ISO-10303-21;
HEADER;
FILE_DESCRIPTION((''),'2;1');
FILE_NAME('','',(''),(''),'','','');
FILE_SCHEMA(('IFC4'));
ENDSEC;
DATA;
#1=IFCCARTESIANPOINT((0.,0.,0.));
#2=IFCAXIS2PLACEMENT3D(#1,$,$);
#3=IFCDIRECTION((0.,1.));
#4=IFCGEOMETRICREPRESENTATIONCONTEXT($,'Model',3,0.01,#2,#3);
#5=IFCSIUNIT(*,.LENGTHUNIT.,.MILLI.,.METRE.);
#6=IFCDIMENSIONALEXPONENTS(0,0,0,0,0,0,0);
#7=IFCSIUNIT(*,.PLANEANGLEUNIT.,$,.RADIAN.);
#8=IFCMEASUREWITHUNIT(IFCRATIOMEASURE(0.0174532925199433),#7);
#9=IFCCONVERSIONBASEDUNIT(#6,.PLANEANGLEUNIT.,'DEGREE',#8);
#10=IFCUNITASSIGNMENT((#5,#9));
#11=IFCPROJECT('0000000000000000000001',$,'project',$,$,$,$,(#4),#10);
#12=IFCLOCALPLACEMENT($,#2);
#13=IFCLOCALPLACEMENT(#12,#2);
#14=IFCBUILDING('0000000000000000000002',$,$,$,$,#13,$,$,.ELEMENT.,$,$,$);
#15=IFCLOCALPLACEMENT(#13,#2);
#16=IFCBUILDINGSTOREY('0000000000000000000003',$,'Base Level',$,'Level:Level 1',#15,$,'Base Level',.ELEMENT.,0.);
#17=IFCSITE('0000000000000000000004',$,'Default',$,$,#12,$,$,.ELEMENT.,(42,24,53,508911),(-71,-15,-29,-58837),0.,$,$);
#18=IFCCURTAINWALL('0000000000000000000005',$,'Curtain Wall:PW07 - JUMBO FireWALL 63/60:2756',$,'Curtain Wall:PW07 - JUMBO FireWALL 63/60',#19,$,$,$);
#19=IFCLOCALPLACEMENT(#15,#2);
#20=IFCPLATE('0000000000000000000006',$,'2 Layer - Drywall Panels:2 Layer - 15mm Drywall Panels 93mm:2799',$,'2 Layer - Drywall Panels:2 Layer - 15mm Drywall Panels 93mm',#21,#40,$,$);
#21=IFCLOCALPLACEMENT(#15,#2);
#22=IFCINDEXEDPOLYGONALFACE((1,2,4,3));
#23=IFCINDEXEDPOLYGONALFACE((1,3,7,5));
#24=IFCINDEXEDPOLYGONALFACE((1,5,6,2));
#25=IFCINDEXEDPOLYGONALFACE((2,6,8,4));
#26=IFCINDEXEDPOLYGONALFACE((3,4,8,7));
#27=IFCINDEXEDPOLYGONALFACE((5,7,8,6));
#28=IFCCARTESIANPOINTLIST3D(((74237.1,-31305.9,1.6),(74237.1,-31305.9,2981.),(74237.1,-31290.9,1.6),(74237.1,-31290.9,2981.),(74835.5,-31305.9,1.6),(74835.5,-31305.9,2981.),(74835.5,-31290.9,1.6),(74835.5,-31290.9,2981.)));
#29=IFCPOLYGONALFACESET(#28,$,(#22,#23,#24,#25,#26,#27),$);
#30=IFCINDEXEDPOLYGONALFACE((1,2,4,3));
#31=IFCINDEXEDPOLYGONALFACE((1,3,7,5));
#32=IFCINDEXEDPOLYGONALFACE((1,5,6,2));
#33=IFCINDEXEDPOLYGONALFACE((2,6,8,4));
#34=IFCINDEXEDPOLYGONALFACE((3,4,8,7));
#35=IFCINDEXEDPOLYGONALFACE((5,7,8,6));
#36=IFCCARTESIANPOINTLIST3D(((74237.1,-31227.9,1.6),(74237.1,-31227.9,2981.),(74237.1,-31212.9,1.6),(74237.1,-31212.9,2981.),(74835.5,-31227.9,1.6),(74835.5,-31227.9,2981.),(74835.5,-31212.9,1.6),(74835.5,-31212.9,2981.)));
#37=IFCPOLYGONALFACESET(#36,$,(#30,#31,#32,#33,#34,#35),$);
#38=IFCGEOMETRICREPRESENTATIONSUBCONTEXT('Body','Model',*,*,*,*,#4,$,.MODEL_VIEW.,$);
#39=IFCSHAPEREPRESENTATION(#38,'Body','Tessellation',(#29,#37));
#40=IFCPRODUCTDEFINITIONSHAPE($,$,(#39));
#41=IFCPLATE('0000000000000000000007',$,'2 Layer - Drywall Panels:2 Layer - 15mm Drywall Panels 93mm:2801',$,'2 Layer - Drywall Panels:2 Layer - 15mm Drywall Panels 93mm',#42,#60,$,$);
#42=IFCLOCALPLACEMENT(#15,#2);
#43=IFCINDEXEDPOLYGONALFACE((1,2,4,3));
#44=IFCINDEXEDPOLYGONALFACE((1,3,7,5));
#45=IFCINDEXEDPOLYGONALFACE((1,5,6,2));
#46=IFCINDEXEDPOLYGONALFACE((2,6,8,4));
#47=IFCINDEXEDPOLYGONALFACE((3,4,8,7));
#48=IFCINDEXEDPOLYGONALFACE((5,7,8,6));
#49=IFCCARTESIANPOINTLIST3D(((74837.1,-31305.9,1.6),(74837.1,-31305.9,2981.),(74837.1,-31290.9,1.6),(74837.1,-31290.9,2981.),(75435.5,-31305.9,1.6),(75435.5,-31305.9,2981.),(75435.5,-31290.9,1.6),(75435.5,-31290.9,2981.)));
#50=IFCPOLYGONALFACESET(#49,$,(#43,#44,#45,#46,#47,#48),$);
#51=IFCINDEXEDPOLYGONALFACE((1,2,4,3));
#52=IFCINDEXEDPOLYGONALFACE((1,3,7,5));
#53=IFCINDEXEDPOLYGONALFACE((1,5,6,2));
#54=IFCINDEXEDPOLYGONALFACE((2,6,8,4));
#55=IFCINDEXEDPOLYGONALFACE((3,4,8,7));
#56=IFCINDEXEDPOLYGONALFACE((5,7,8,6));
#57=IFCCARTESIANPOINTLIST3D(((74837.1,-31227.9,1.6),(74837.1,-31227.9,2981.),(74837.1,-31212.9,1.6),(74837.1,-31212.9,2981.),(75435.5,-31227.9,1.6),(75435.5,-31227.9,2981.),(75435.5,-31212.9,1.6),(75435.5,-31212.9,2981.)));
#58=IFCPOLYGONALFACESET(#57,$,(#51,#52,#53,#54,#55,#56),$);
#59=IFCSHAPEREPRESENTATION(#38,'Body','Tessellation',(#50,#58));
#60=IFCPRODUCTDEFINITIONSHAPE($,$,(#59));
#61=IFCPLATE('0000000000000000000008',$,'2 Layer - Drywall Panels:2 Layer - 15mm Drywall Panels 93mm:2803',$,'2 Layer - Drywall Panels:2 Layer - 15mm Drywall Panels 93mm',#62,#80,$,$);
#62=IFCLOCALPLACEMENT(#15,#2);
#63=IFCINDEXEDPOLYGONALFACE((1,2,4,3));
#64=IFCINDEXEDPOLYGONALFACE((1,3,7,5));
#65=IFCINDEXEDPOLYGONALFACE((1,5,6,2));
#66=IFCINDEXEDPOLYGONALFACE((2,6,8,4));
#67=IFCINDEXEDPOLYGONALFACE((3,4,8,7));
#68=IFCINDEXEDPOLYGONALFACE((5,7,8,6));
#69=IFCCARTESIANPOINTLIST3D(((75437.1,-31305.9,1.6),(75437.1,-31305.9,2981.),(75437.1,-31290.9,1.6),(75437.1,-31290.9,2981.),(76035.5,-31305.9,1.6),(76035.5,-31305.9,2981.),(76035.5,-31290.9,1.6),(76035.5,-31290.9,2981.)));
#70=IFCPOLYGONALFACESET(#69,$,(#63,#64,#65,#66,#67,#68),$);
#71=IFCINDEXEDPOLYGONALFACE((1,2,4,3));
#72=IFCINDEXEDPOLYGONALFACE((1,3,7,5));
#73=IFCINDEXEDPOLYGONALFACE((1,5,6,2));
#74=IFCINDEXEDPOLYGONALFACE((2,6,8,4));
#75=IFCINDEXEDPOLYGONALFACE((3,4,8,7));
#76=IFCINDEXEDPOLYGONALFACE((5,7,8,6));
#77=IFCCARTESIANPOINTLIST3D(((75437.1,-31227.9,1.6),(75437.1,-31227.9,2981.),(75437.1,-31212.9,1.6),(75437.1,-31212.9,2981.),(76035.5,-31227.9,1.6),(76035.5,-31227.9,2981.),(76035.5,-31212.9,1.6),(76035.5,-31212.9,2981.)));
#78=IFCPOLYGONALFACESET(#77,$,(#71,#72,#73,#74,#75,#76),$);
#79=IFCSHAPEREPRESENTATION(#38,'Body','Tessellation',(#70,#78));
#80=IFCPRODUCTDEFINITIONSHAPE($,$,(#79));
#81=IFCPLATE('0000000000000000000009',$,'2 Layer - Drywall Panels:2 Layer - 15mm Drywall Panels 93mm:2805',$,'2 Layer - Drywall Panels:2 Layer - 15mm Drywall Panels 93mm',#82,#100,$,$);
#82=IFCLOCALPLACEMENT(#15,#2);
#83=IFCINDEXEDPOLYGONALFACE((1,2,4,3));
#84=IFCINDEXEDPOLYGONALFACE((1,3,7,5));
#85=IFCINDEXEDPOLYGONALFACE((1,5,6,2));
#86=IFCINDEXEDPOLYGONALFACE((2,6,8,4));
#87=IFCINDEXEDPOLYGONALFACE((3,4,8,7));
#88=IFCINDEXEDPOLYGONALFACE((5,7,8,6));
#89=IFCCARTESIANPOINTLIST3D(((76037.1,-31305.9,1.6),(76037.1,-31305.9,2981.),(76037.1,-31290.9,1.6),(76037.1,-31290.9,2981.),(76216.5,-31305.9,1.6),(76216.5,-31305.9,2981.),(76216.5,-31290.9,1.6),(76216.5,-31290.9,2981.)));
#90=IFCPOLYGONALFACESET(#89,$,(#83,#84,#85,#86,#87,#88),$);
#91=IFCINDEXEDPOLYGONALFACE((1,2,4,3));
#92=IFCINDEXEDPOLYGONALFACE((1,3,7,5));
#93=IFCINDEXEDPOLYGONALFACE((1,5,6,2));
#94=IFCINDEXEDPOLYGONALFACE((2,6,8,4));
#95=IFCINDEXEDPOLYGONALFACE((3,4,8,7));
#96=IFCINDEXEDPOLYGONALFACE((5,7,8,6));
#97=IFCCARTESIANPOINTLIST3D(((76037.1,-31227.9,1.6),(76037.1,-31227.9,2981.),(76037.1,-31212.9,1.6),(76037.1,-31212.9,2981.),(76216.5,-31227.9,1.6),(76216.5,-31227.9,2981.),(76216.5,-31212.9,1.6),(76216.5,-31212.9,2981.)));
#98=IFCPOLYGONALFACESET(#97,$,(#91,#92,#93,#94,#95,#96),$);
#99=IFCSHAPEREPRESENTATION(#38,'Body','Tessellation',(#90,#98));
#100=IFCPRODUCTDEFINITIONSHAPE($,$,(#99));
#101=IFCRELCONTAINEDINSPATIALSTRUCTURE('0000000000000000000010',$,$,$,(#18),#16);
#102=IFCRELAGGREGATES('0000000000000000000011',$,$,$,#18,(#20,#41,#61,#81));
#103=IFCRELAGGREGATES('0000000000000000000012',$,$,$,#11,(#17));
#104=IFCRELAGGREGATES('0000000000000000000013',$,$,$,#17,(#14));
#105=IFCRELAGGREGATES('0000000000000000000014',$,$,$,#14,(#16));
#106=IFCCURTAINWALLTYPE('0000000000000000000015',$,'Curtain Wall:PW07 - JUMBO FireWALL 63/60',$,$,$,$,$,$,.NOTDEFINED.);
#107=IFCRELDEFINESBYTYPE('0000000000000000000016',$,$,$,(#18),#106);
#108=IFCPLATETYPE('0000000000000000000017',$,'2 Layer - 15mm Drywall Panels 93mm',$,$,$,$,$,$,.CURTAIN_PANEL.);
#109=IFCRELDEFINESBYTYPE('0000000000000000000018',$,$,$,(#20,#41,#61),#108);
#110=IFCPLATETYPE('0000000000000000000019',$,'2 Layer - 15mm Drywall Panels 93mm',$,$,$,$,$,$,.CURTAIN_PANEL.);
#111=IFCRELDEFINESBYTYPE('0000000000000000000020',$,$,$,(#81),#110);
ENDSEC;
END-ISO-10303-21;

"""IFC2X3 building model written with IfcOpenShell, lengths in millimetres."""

from ifc_helpers import new_model, entity, si_unit, converted_unit, direction, frame, frame_2d, origin, place, context, subcontext, project, spatial, rectangle, extrude, source, transform, mapped, type_object, type_shapes, element, aggregate, save


model = new_model("IFC2X3")

# Units and contexts
model_context = context("Model", 3, precision=0.01, world=origin(), true_north=direction((0.0, 1.0)))
body_context = subcontext(model_context, "Body", "Model", "MODEL_VIEW")
ifc_project = project(units=[si_unit("LENGTHUNIT", "METRE", prefix="MILLI"), converted_unit("PLANEANGLEUNIT", "DEGREE", entity("IfcRatioMeasure", 0.0174532925199433), si_unit("PLANEANGLEUNIT", "RADIAN"), dimensions=[0, 0, 0, 0, 0, 0, 0])], contexts=[model_context])

# Site, building, storey
site_placement = place(None, origin())
site = spatial("IfcSite", under=ifc_project, at=site_placement, Name="Default", CompositionType="ELEMENT", RefLatitude=(42, 24, 53, 508911), RefLongitude=(-71, -15, -29, -58837), RefElevation=0.0)
building_placement = place(site_placement, origin())
building = spatial("IfcBuilding", under=site, at=building_placement, CompositionType="ELEMENT")
storey_placement = place(building_placement, origin())
storey = spatial("IfcBuildingStorey", under=building, at=storey_placement, Name="Base Level", ObjectType="Level:Level 1", LongName="Base Level", CompositionType="ELEMENT", Elevation=0.0)

# Curtain wall, plates
curtain_wall_type = type_object("IfcCurtainWallType", Name="Curtain Wall:PW07 - JUMBO FireWALL 63/60", PredefinedType="NOTDEFINED")
curtain_wall_placement = place(building_placement, origin())
curtain_wall = element("IfcCurtainWall", 1, at=curtain_wall_placement, inside=storey, type_object=curtain_wall_type, Name="Curtain Wall:PW07 - JUMBO FireWALL 63/60:2756", ObjectType="Curtain Wall:PW07 - JUMBO FireWALL 63/60")
plate_type_1 = type_object("IfcPlateType", Name="2 Layer - 15mm Drywall Panels 93mm", PredefinedType="CURTAIN_PANEL")
shared_shape_1 = source(origin(), body_context, "Body", "SweptSolid", [
    extrude(rectangle(XDim=598.4, YDim=15.0, at=frame_2d((0.0, 0.0), x_axis=(1.0, 0.0))), frame((0.0, -39.0, 0.0), z_axis=(0.0, 0.0, 1.0), x_axis=(-1.0, 0.0, 0.0)), (0.0, 0.0, 1.0), 2979.4),
    extrude(rectangle(XDim=15.0, YDim=598.4, at=frame_2d((0.0, 0.0), x_axis=(1.0, 0.0))), frame((0.0, 39.0, 0.0), z_axis=(0.0, 0.0, 1.0), x_axis=(0.0, 1.0, 0.0)), (0.0, 0.0, 1.0), 2979.4),
])
type_shapes(plate_type_1, [shared_shape_1])
plate_1_placement = place(curtain_wall_placement, frame((74536.3, -31259.4, 1.6)))
plate_1 = element("IfcPlate", 2, at=plate_1_placement, type_object=plate_type_1, Name="2 Layer - Drywall Panels:2 Layer - 15mm Drywall Panels 93mm:2799", ObjectType="2 Layer - Drywall Panels:2 Layer - 15mm Drywall Panels 93mm", context=body_context, shape_type="MappedRepresentation", body=[
    mapped(shared_shape_1, transform((0.0, 0.0, 0.0), scale=1.0)),
])
plate_2_placement = place(curtain_wall_placement, frame((75136.3, -31259.4, 1.6)))
plate_2 = element("IfcPlate", 3, at=plate_2_placement, type_object=plate_type_1, Name="2 Layer - Drywall Panels:2 Layer - 15mm Drywall Panels 93mm:2801", ObjectType="2 Layer - Drywall Panels:2 Layer - 15mm Drywall Panels 93mm", context=body_context, shape_type="MappedRepresentation", body=[
    mapped(shared_shape_1, transform((0.0, 0.0, 0.0), scale=1.0)),
])
plate_3_placement = place(curtain_wall_placement, frame((75736.3, -31259.4, 1.6)))
plate_3 = element("IfcPlate", 4, at=plate_3_placement, type_object=plate_type_1, Name="2 Layer - Drywall Panels:2 Layer - 15mm Drywall Panels 93mm:2803", ObjectType="2 Layer - Drywall Panels:2 Layer - 15mm Drywall Panels 93mm", context=body_context, shape_type="MappedRepresentation", body=[
    mapped(shared_shape_1, transform((0.0, 0.0, 0.0), scale=1.0)),
])
plate_type_2 = type_object("IfcPlateType", Name="2 Layer - 15mm Drywall Panels 93mm", PredefinedType="CURTAIN_PANEL")
shared_shape_2 = source(origin(), body_context, "Body", "SweptSolid", [
    extrude(rectangle(XDim=179.4, YDim=15.0, at=frame_2d((0.0, 0.0), x_axis=(1.0, 0.0))), frame((0.0, -39.0, 0.0), z_axis=(0.0, 0.0, 1.0), x_axis=(-1.0, 0.0, 0.0)), (0.0, 0.0, 1.0), 2979.4),
    extrude(rectangle(XDim=15.0, YDim=179.4, at=frame_2d((0.0, 0.0), x_axis=(1.0, 0.0))), frame((0.0, 39.0, 0.0), z_axis=(0.0, 0.0, 1.0), x_axis=(0.0, 1.0, 0.0)), (0.0, 0.0, 1.0), 2979.4),
])
type_shapes(plate_type_2, [shared_shape_2])
plate_4_placement = place(curtain_wall_placement, frame((76126.8, -31259.4, 1.6)))
plate_4 = element("IfcPlate", 5, at=plate_4_placement, type_object=plate_type_2, Name="2 Layer - Drywall Panels:2 Layer - 15mm Drywall Panels 93mm:2805", ObjectType="2 Layer - Drywall Panels:2 Layer - 15mm Drywall Panels 93mm", context=body_context, shape_type="MappedRepresentation", body=[
    mapped(shared_shape_2, transform((0.0, 0.0, 0.0), scale=1.0)),
])
aggregate(curtain_wall, [plate_1, plate_2, plate_3, plate_4])

save(model, "model.ifc")
